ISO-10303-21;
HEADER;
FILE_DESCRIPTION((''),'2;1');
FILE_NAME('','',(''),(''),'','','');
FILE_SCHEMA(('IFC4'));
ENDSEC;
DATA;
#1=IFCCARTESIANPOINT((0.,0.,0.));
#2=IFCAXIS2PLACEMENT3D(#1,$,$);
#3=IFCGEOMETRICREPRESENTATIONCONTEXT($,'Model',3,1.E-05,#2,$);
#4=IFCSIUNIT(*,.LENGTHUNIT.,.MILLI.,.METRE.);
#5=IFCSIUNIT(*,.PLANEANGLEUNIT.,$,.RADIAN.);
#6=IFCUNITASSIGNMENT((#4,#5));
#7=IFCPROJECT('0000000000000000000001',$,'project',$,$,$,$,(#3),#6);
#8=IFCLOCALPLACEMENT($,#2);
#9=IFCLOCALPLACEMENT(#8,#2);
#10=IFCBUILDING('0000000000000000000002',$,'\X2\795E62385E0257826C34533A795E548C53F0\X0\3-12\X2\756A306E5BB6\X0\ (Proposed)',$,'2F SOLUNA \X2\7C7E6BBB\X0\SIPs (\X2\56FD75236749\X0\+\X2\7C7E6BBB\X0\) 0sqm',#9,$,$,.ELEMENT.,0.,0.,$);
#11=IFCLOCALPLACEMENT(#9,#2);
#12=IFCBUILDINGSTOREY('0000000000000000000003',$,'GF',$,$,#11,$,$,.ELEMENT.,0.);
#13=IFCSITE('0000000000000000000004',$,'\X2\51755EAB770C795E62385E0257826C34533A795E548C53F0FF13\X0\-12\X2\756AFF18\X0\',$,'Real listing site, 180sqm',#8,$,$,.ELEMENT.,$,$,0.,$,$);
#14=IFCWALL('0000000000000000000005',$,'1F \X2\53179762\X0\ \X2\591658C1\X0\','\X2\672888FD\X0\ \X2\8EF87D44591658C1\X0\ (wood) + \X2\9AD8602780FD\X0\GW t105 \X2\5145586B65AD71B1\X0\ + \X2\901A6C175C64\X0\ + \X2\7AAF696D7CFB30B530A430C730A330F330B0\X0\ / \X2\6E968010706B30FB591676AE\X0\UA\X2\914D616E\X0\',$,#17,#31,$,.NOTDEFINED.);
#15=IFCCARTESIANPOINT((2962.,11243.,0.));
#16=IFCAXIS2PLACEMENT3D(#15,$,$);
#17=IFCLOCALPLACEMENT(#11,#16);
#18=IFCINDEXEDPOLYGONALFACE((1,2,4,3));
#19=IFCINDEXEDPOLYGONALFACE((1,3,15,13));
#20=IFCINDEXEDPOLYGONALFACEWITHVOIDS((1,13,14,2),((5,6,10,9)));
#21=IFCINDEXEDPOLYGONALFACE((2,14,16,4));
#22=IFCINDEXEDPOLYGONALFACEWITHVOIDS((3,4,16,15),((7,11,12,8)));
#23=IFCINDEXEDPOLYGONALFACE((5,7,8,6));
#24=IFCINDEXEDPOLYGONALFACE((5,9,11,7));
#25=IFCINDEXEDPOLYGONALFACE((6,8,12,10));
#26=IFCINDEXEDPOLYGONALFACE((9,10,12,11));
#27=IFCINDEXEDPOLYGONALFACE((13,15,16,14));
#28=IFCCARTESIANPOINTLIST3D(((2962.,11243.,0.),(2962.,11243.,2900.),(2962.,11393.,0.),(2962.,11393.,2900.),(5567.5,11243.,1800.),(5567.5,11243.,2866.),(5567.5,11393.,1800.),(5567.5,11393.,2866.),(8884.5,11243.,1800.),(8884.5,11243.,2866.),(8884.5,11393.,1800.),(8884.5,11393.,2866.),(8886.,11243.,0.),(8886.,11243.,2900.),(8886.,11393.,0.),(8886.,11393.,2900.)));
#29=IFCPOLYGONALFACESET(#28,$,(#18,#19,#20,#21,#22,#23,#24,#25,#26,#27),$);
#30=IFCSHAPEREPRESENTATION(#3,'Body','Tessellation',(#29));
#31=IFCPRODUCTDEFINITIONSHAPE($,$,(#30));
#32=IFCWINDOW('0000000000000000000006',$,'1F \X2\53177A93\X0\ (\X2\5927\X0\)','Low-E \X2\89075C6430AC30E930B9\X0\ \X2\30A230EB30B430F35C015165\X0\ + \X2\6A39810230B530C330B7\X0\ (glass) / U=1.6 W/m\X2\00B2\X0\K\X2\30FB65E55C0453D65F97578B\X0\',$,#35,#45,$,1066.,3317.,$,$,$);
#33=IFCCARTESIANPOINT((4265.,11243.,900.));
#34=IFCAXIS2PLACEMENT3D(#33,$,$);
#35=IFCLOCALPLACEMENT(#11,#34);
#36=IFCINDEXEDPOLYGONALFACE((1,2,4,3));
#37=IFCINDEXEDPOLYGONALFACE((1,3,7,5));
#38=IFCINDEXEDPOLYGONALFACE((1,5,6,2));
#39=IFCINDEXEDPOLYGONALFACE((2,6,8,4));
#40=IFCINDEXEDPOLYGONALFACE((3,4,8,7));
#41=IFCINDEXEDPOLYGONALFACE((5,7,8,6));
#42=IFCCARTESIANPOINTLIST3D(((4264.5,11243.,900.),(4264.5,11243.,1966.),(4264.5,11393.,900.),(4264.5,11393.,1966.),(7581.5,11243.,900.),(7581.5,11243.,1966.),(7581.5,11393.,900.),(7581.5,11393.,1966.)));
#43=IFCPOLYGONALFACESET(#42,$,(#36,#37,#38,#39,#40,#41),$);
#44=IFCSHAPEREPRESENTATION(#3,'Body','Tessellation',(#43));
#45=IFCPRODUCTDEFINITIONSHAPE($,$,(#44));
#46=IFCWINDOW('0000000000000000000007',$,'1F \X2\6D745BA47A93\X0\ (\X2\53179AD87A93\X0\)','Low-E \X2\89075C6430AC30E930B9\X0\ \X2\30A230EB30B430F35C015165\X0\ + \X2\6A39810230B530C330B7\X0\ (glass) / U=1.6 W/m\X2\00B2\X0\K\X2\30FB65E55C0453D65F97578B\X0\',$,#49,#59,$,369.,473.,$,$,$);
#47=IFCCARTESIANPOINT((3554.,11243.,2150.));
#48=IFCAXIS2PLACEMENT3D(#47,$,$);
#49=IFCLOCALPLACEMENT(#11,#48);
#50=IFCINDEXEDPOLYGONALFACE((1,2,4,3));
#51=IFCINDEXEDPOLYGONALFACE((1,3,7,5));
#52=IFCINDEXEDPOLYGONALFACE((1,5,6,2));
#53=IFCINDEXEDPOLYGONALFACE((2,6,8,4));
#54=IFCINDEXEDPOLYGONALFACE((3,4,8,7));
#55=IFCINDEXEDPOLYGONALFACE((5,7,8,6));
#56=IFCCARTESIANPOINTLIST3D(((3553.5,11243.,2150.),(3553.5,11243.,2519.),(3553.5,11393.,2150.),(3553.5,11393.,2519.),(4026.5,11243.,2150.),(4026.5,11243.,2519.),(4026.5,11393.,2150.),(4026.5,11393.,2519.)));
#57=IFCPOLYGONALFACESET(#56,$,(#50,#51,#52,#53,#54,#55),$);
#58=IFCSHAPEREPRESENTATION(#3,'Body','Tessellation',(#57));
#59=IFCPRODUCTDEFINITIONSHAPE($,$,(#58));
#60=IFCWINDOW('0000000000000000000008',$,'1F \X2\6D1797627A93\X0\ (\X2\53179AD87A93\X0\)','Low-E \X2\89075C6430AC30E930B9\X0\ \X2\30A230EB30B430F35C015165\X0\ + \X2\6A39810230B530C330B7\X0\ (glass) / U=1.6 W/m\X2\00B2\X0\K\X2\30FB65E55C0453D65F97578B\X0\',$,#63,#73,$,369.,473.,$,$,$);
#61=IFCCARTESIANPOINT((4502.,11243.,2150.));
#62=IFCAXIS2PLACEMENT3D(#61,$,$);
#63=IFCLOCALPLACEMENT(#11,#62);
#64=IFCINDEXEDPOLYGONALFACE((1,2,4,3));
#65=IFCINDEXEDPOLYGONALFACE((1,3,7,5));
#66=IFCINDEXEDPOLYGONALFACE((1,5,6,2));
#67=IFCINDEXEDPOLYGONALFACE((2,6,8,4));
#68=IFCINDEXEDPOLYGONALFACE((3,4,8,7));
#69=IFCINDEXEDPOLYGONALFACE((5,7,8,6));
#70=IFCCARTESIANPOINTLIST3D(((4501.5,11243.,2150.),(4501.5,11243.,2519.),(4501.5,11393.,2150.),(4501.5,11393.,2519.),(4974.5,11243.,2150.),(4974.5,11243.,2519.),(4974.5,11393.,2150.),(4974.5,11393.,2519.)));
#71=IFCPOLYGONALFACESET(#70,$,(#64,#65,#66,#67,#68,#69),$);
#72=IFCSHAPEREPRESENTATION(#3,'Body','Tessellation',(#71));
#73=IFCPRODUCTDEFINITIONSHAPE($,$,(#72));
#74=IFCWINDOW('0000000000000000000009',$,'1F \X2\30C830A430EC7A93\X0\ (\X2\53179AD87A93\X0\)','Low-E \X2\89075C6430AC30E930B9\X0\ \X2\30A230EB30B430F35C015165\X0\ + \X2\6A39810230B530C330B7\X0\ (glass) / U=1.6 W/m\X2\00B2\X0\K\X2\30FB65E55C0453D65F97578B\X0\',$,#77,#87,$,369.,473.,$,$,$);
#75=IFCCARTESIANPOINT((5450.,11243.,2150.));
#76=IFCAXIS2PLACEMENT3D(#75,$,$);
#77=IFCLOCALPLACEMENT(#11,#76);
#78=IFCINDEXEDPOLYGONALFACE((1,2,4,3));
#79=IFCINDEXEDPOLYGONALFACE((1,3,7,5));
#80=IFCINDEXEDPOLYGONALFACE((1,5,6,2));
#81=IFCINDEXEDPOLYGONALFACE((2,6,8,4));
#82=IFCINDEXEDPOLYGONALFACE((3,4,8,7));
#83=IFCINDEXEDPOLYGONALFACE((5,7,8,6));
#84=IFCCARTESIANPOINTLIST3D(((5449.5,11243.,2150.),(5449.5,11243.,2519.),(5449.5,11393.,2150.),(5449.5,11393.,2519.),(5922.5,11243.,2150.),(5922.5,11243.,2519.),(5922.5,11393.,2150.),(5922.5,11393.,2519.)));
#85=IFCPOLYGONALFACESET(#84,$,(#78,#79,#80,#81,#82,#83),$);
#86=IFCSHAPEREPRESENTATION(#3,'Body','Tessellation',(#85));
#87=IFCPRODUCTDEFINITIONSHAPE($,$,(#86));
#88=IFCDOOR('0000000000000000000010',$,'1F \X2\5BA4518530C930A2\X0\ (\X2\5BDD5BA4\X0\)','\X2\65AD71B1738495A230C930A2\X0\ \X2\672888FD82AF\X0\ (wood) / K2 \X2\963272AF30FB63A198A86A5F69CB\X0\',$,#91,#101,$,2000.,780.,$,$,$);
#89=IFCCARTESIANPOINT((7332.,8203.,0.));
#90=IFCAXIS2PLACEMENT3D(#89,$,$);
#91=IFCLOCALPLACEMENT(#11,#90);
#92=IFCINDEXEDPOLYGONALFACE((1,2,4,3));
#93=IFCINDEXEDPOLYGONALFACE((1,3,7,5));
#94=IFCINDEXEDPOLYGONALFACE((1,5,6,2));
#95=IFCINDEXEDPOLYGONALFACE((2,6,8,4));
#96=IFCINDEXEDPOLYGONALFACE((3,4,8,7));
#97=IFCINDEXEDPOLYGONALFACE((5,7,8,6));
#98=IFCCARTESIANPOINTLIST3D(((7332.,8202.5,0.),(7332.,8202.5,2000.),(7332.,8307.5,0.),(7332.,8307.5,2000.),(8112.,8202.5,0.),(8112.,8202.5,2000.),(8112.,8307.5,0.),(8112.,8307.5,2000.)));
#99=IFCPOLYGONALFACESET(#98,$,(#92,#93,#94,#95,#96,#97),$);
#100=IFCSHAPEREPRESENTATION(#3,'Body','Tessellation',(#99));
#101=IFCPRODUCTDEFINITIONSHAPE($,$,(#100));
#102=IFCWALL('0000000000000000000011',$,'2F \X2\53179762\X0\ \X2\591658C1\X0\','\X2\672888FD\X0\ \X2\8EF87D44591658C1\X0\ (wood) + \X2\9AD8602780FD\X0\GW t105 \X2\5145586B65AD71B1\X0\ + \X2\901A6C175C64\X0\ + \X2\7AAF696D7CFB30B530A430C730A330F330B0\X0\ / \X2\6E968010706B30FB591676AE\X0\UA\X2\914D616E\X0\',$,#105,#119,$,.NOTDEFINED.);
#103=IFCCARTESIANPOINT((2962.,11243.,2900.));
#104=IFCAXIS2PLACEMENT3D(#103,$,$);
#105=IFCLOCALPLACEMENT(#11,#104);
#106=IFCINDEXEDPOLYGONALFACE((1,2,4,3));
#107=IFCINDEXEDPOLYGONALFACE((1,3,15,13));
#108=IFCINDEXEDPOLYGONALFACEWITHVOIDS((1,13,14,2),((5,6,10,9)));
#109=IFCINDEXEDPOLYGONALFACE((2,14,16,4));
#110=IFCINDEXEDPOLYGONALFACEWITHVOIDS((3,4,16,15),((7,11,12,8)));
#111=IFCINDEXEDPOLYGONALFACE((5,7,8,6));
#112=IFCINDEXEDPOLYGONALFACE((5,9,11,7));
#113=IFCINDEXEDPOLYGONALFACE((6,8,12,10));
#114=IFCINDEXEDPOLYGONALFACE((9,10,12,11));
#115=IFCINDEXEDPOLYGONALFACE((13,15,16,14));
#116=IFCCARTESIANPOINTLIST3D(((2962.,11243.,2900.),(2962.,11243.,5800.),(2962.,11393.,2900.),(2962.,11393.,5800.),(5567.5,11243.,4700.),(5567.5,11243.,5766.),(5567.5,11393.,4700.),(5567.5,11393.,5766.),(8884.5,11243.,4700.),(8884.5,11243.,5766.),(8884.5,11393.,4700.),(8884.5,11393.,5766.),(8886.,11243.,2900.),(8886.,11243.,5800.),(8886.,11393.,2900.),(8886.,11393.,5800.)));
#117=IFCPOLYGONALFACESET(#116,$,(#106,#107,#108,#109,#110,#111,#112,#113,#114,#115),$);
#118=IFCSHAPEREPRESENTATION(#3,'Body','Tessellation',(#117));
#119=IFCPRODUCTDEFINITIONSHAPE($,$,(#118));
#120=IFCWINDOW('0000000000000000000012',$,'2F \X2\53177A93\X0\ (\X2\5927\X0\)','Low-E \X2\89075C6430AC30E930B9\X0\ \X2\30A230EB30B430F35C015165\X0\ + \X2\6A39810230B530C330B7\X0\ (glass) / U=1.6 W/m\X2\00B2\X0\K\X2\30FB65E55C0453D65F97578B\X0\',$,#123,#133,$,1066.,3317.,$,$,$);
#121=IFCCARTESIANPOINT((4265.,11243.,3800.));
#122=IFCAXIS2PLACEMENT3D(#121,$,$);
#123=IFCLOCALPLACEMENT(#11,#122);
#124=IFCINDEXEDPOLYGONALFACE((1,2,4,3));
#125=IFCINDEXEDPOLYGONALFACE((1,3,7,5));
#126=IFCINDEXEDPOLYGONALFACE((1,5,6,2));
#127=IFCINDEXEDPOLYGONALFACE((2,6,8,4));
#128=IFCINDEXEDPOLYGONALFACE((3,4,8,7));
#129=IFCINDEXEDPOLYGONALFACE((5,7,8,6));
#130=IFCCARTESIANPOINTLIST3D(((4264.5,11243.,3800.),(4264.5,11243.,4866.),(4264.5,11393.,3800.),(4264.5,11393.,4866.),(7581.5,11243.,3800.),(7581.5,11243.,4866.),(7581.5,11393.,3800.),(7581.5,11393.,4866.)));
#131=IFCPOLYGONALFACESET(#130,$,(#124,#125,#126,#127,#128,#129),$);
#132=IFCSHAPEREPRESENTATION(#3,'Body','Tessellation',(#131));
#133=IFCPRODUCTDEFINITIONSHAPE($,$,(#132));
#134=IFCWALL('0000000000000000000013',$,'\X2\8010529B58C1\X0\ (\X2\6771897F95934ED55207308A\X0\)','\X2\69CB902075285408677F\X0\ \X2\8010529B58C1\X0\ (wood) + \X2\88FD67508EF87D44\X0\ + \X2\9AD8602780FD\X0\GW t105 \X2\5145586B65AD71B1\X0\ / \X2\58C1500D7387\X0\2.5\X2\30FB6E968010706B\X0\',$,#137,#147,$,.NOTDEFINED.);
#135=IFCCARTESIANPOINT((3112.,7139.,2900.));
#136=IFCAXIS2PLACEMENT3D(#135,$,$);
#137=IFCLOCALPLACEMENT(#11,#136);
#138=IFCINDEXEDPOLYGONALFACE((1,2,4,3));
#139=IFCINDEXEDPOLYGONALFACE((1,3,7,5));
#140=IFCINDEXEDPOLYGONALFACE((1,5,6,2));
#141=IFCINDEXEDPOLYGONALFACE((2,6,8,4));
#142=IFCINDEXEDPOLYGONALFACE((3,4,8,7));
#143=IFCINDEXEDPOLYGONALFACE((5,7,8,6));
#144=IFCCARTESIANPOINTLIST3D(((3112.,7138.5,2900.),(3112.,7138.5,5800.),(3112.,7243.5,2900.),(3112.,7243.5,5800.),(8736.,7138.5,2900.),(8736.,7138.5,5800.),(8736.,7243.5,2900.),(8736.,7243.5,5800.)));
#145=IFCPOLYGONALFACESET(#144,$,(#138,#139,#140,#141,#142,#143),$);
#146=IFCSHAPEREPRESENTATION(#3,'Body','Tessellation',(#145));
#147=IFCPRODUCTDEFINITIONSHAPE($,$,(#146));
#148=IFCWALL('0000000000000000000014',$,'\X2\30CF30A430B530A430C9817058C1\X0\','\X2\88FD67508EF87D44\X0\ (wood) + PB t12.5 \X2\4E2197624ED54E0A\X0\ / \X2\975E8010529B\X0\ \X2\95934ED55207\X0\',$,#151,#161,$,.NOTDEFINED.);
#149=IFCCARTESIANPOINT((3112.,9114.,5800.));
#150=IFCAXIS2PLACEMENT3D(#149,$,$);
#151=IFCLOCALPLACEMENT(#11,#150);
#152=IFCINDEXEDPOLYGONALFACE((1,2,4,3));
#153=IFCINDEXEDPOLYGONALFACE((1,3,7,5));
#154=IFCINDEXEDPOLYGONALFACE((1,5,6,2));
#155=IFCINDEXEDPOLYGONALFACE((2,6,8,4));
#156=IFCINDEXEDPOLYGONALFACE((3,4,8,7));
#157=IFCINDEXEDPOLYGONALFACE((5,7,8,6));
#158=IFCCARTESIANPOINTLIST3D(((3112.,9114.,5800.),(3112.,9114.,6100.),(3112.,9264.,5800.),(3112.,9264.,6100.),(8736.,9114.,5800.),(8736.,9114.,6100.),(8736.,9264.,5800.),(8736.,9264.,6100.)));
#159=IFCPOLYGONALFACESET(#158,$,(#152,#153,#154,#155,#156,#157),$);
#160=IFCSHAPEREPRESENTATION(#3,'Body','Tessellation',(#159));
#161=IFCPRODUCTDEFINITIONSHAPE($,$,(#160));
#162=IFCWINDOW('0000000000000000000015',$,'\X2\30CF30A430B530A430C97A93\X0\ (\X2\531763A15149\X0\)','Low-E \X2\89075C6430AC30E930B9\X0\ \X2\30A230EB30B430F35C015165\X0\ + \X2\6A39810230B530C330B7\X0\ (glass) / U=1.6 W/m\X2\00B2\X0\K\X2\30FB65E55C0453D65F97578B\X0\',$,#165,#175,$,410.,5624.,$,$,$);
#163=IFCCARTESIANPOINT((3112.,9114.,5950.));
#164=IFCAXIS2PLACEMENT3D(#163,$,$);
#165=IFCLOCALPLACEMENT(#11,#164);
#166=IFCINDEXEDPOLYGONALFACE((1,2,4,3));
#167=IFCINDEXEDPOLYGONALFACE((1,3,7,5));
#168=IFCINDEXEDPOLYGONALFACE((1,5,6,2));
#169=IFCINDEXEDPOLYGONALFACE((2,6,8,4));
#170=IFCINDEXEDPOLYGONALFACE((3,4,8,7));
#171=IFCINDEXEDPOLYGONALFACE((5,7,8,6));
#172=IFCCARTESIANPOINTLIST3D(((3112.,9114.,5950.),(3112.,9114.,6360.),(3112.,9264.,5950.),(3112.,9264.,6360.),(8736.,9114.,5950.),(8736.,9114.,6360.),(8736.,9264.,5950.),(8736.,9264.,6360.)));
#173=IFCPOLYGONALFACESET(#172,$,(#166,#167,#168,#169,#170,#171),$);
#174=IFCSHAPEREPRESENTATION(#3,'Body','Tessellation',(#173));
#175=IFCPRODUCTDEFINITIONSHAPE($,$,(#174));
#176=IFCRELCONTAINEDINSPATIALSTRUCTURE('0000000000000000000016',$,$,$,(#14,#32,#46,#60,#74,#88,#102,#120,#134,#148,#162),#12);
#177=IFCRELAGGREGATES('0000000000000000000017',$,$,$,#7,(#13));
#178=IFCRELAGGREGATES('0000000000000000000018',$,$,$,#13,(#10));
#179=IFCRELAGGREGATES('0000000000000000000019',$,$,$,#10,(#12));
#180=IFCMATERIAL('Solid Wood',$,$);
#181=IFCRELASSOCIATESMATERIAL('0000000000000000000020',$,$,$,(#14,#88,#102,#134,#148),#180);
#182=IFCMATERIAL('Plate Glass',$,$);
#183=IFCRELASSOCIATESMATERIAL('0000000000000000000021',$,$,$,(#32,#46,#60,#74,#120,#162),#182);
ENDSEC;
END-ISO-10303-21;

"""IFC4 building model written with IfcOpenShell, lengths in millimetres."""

from ifc_helpers import new_model, si_unit, frame, frame_2d, origin, place, context, project, spatial, rectangle, extrude, material, element, fill, save


model = new_model("IFC4")

# Units and contexts
model_context = context("Model", 3, precision=1e-05, world=origin())
ifc_project = project(units=[si_unit("LENGTHUNIT", "METRE", prefix="MILLI"), si_unit("PLANEANGLEUNIT", "RADIAN")], contexts=[model_context])

# Site, building, storey
site_placement = place(None, origin())
site = spatial("IfcSite", under=ifc_project, at=site_placement, Name="兵庫県神戸市垂水区神和台３-12番８", ObjectType="Real listing site, 180sqm", CompositionType="ELEMENT", RefElevation=0.0)
building_placement = place(site_placement, origin())
building = spatial("IfcBuilding", under=site, at=building_placement, Name="神戸市垂水区神和台3-12番の家 (Proposed)", ObjectType="2F SOLUNA 籾殻SIPs (国産杉+籾殻) 0sqm", CompositionType="ELEMENT", ElevationOfRefHeight=0.0, ElevationOfTerrain=0.0)
storey_placement = place(building_placement, origin())
storey = spatial("IfcBuildingStorey", under=building, at=storey_placement, Name="GF", CompositionType="ELEMENT", Elevation=0.0)

# Wall, openings, windows
ifc_material_1 = material(Name="Solid Wood")
wall_1_placement = place(storey_placement, frame((2962.0, 11243.0, 0.0)))
wall_1 = element("IfcWall", 1, at=wall_1_placement, inside=storey, material=ifc_material_1, Name="1F 北面 外壁", Description="木製 軸組外壁 (wood) + 高性能GW t105 充填断熱 + 通気層 + 窯業系サイディング / 準耐火・外皮UA配慮", PredefinedType="NOTDEFINED", context=model_context, shape_type="SweptSolid", body=[
    extrude(rectangle(XDim=5924.0, YDim=150.0, at=frame_2d((2962.0, 75.0))), frame((2962.0, 11243.0, 0.0)), (0.0, 0.0, 1.0), 2900.0),
])
opening_1_placement = place(storey_placement, frame((4265.0, 11243.0, 900.0)))
opening_1 = element("IfcOpeningElement", 2, at=opening_1_placement, cuts=wall_1, PredefinedType="NOTDEFINED", context=model_context, shape_type="SweptSolid", body=[
    extrude(rectangle(XDim=3317.0, YDim=150.0, at=frame_2d((1658.0, 75.0))), frame((4265.0, 11243.0, 900.0)), (0.0, 0.0, 1.0), 1066.0),
])
opening_2_placement = place(storey_placement, frame((3554.0, 11243.0, 2150.0)))
opening_2 = element("IfcOpeningElement", 3, at=opening_2_placement, cuts=wall_1, PredefinedType="NOTDEFINED", context=model_context, shape_type="SweptSolid", body=[
    extrude(rectangle(XDim=473.0, YDim=150.0, at=frame_2d((236.0, 75.0))), frame((3554.0, 11243.0, 2150.0)), (0.0, 0.0, 1.0), 369.0),
])
opening_3_placement = place(storey_placement, frame((4502.0, 11243.0, 2150.0)))
opening_3 = element("IfcOpeningElement", 4, at=opening_3_placement, cuts=wall_1, PredefinedType="NOTDEFINED", context=model_context, shape_type="SweptSolid", body=[
    extrude(rectangle(XDim=473.0, YDim=150.0, at=frame_2d((236.0, 75.0))), frame((4502.0, 11243.0, 2150.0)), (0.0, 0.0, 1.0), 369.0),
])
opening_4_placement = place(storey_placement, frame((5450.0, 11243.0, 2150.0)))
opening_4 = element("IfcOpeningElement", 5, at=opening_4_placement, cuts=wall_1, PredefinedType="NOTDEFINED", context=model_context, shape_type="SweptSolid", body=[
    extrude(rectangle(XDim=473.0, YDim=150.0, at=frame_2d((236.0, 75.0))), frame((5450.0, 11243.0, 2150.0)), (0.0, 0.0, 1.0), 369.0),
])
ifc_material_2 = material(Name="Plate Glass")
window_1_placement = place(storey_placement, frame((4265.0, 11243.0, 900.0)))
window_1 = element("IfcWindow", 6, at=window_1_placement, inside=storey, material=ifc_material_2, Name="1F 北窓 (大)", Description="Low-E 複層ガラス アルゴン封入 + 樹脂サッシ (glass) / U=1.6 W/m²K・日射取得型", OverallHeight=1066.0, OverallWidth=3317.0, context=model_context, shape_type="SweptSolid", body=[
    extrude(rectangle(XDim=3317.0, YDim=150.0, at=frame_2d((1658.0, 75.0))), frame((4265.0, 11243.0, 900.0)), (0.0, 0.0, 1.0), 1066.0),
])
fill(opening_1, window_1)
window_2_placement = place(storey_placement, frame((3554.0, 11243.0, 2150.0)))
window_2 = element("IfcWindow", 7, at=window_2_placement, inside=storey, material=ifc_material_2, Name="1F 浴室窓 (北高窓)", Description="Low-E 複層ガラス アルゴン封入 + 樹脂サッシ (glass) / U=1.6 W/m²K・日射取得型", OverallHeight=369.0, OverallWidth=473.0, context=model_context, shape_type="SweptSolid", body=[
    extrude(rectangle(XDim=473.0, YDim=150.0, at=frame_2d((236.0, 75.0))), frame((3554.0, 11243.0, 2150.0)), (0.0, 0.0, 1.0), 369.0),
])
fill(opening_2, window_2)
window_3_placement = place(storey_placement, frame((4502.0, 11243.0, 2150.0)))
window_3 = element("IfcWindow", 8, at=window_3_placement, inside=storey, material=ifc_material_2, Name="1F 洗面窓 (北高窓)", Description="Low-E 複層ガラス アルゴン封入 + 樹脂サッシ (glass) / U=1.6 W/m²K・日射取得型", OverallHeight=369.0, OverallWidth=473.0, context=model_context, shape_type="SweptSolid", body=[
    extrude(rectangle(XDim=473.0, YDim=150.0, at=frame_2d((236.0, 75.0))), frame((4502.0, 11243.0, 2150.0)), (0.0, 0.0, 1.0), 369.0),
])
fill(opening_3, window_3)
window_4_placement = place(storey_placement, frame((5450.0, 11243.0, 2150.0)))
window_4 = element("IfcWindow", 9, at=window_4_placement, inside=storey, material=ifc_material_2, Name="1F トイレ窓 (北高窓)", Description="Low-E 複層ガラス アルゴン封入 + 樹脂サッシ (glass) / U=1.6 W/m²K・日射取得型", OverallHeight=369.0, OverallWidth=473.0, context=model_context, shape_type="SweptSolid", body=[
    extrude(rectangle(XDim=473.0, YDim=150.0, at=frame_2d((236.0, 75.0))), frame((5450.0, 11243.0, 2150.0)), (0.0, 0.0, 1.0), 369.0),
])
fill(opening_4, window_4)

# Door
door_1_placement = place(storey_placement, frame((7332.0, 8203.0, 0.0)))
element("IfcDoor", 10, at=door_1_placement, inside=storey, material=ifc_material_1, Name="1F 室内ドア (寝室)", Description="断熱玄関ドア 木製芯 (wood) / K2 防犯・採風機構", OverallHeight=2000.0, OverallWidth=780.0, context=model_context, shape_type="SweptSolid", body=[
    extrude(rectangle(XDim=780.0, YDim=105.0, at=frame_2d((390.0, 52.0))), frame((7332.0, 8203.0, 0.0)), (0.0, 0.0, 1.0), 2000.0),
])

# Wall, opening, window
wall_2_placement = place(storey_placement, frame((2962.0, 11243.0, 2900.0)))
wall_2 = element("IfcWall", 11, at=wall_2_placement, inside=storey, material=ifc_material_1, Name="2F 北面 外壁", Description="木製 軸組外壁 (wood) + 高性能GW t105 充填断熱 + 通気層 + 窯業系サイディング / 準耐火・外皮UA配慮", PredefinedType="NOTDEFINED", context=model_context, shape_type="SweptSolid", body=[
    extrude(rectangle(XDim=5924.0, YDim=150.0, at=frame_2d((2962.0, 75.0))), frame((2962.0, 11243.0, 2900.0)), (0.0, 0.0, 1.0), 2900.0),
])
opening_5_placement = place(storey_placement, frame((4265.0, 11243.0, 3800.0)))
opening_5 = element("IfcOpeningElement", 12, at=opening_5_placement, cuts=wall_2, PredefinedType="NOTDEFINED", context=model_context, shape_type="SweptSolid", body=[
    extrude(rectangle(XDim=3317.0, YDim=150.0, at=frame_2d((1658.0, 75.0))), frame((4265.0, 11243.0, 3800.0)), (0.0, 0.0, 1.0), 1066.0),
])
window_5_placement = place(storey_placement, frame((4265.0, 11243.0, 3800.0)))
window_5 = element("IfcWindow", 13, at=window_5_placement, inside=storey, material=ifc_material_2, Name="2F 北窓 (大)", Description="Low-E 複層ガラス アルゴン封入 + 樹脂サッシ (glass) / U=1.6 W/m²K・日射取得型", OverallHeight=1066.0, OverallWidth=3317.0, context=model_context, shape_type="SweptSolid", body=[
    extrude(rectangle(XDim=3317.0, YDim=150.0, at=frame_2d((1658.0, 75.0))), frame((4265.0, 11243.0, 3800.0)), (0.0, 0.0, 1.0), 1066.0),
])
fill(opening_5, window_5)

# Wall
wall_3_placement = place(storey_placement, frame((3112.0, 7139.0, 2900.0)))
element("IfcWall", 14, at=wall_3_placement, inside=storey, material=ifc_material_1, Name="耐力壁 (東西間仕切り)", Description="構造用合板 耐力壁 (wood) + 製材軸組 + 高性能GW t105 充填断熱 / 壁倍率2.5・準耐火", PredefinedType="NOTDEFINED", context=model_context, shape_type="SweptSolid", body=[
    extrude(rectangle(XDim=5624.0, YDim=105.0, at=frame_2d((2812.0, 52.0))), frame((3112.0, 7139.0, 2900.0)), (0.0, 0.0, 1.0), 2900.0),
])

# Wall, opening, window
wall_4_placement = place(storey_placement, frame((3112.0, 9114.0, 5800.0)))
wall_4 = element("IfcWall", 15, at=wall_4_placement, inside=storey, material=ifc_material_1, Name="ハイサイド腰壁", Description="製材軸組 (wood) + PB t12.5 両面仕上 / 非耐力 間仕切", PredefinedType="NOTDEFINED", context=model_context, shape_type="SweptSolid", body=[
    extrude(rectangle(XDim=5624.0, YDim=150.0, at=frame_2d((2812.0, 75.0))), frame((3112.0, 9114.0, 5800.0)), (0.0, 0.0, 1.0), 700.0),
])
opening_6_placement = place(storey_placement, frame((3112.0, 9114.0, 5950.0)))
opening_6 = element("IfcOpeningElement", 16, at=opening_6_placement, cuts=wall_4, PredefinedType="NOTDEFINED", context=model_context, shape_type="SweptSolid", body=[
    extrude(rectangle(XDim=5624.0, YDim=150.0, at=frame_2d((2812.0, 75.0))), frame((3112.0, 9114.0, 5950.0)), (0.0, 0.0, 1.0), 410.0),
])
window_6_placement = place(storey_placement, frame((3112.0, 9114.0, 5950.0)))
window_6 = element("IfcWindow", 17, at=window_6_placement, inside=storey, material=ifc_material_2, Name="ハイサイド窓 (北採光)", Description="Low-E 複層ガラス アルゴン封入 + 樹脂サッシ (glass) / U=1.6 W/m²K・日射取得型", OverallHeight=410.0, OverallWidth=5624.0, context=model_context, shape_type="SweptSolid", body=[
    extrude(rectangle(XDim=5624.0, YDim=150.0, at=frame_2d((2812.0, 75.0))), frame((3112.0, 9114.0, 5950.0)), (0.0, 0.0, 1.0), 410.0),
])
fill(opening_6, window_6)

save(model, "model.ifc")
